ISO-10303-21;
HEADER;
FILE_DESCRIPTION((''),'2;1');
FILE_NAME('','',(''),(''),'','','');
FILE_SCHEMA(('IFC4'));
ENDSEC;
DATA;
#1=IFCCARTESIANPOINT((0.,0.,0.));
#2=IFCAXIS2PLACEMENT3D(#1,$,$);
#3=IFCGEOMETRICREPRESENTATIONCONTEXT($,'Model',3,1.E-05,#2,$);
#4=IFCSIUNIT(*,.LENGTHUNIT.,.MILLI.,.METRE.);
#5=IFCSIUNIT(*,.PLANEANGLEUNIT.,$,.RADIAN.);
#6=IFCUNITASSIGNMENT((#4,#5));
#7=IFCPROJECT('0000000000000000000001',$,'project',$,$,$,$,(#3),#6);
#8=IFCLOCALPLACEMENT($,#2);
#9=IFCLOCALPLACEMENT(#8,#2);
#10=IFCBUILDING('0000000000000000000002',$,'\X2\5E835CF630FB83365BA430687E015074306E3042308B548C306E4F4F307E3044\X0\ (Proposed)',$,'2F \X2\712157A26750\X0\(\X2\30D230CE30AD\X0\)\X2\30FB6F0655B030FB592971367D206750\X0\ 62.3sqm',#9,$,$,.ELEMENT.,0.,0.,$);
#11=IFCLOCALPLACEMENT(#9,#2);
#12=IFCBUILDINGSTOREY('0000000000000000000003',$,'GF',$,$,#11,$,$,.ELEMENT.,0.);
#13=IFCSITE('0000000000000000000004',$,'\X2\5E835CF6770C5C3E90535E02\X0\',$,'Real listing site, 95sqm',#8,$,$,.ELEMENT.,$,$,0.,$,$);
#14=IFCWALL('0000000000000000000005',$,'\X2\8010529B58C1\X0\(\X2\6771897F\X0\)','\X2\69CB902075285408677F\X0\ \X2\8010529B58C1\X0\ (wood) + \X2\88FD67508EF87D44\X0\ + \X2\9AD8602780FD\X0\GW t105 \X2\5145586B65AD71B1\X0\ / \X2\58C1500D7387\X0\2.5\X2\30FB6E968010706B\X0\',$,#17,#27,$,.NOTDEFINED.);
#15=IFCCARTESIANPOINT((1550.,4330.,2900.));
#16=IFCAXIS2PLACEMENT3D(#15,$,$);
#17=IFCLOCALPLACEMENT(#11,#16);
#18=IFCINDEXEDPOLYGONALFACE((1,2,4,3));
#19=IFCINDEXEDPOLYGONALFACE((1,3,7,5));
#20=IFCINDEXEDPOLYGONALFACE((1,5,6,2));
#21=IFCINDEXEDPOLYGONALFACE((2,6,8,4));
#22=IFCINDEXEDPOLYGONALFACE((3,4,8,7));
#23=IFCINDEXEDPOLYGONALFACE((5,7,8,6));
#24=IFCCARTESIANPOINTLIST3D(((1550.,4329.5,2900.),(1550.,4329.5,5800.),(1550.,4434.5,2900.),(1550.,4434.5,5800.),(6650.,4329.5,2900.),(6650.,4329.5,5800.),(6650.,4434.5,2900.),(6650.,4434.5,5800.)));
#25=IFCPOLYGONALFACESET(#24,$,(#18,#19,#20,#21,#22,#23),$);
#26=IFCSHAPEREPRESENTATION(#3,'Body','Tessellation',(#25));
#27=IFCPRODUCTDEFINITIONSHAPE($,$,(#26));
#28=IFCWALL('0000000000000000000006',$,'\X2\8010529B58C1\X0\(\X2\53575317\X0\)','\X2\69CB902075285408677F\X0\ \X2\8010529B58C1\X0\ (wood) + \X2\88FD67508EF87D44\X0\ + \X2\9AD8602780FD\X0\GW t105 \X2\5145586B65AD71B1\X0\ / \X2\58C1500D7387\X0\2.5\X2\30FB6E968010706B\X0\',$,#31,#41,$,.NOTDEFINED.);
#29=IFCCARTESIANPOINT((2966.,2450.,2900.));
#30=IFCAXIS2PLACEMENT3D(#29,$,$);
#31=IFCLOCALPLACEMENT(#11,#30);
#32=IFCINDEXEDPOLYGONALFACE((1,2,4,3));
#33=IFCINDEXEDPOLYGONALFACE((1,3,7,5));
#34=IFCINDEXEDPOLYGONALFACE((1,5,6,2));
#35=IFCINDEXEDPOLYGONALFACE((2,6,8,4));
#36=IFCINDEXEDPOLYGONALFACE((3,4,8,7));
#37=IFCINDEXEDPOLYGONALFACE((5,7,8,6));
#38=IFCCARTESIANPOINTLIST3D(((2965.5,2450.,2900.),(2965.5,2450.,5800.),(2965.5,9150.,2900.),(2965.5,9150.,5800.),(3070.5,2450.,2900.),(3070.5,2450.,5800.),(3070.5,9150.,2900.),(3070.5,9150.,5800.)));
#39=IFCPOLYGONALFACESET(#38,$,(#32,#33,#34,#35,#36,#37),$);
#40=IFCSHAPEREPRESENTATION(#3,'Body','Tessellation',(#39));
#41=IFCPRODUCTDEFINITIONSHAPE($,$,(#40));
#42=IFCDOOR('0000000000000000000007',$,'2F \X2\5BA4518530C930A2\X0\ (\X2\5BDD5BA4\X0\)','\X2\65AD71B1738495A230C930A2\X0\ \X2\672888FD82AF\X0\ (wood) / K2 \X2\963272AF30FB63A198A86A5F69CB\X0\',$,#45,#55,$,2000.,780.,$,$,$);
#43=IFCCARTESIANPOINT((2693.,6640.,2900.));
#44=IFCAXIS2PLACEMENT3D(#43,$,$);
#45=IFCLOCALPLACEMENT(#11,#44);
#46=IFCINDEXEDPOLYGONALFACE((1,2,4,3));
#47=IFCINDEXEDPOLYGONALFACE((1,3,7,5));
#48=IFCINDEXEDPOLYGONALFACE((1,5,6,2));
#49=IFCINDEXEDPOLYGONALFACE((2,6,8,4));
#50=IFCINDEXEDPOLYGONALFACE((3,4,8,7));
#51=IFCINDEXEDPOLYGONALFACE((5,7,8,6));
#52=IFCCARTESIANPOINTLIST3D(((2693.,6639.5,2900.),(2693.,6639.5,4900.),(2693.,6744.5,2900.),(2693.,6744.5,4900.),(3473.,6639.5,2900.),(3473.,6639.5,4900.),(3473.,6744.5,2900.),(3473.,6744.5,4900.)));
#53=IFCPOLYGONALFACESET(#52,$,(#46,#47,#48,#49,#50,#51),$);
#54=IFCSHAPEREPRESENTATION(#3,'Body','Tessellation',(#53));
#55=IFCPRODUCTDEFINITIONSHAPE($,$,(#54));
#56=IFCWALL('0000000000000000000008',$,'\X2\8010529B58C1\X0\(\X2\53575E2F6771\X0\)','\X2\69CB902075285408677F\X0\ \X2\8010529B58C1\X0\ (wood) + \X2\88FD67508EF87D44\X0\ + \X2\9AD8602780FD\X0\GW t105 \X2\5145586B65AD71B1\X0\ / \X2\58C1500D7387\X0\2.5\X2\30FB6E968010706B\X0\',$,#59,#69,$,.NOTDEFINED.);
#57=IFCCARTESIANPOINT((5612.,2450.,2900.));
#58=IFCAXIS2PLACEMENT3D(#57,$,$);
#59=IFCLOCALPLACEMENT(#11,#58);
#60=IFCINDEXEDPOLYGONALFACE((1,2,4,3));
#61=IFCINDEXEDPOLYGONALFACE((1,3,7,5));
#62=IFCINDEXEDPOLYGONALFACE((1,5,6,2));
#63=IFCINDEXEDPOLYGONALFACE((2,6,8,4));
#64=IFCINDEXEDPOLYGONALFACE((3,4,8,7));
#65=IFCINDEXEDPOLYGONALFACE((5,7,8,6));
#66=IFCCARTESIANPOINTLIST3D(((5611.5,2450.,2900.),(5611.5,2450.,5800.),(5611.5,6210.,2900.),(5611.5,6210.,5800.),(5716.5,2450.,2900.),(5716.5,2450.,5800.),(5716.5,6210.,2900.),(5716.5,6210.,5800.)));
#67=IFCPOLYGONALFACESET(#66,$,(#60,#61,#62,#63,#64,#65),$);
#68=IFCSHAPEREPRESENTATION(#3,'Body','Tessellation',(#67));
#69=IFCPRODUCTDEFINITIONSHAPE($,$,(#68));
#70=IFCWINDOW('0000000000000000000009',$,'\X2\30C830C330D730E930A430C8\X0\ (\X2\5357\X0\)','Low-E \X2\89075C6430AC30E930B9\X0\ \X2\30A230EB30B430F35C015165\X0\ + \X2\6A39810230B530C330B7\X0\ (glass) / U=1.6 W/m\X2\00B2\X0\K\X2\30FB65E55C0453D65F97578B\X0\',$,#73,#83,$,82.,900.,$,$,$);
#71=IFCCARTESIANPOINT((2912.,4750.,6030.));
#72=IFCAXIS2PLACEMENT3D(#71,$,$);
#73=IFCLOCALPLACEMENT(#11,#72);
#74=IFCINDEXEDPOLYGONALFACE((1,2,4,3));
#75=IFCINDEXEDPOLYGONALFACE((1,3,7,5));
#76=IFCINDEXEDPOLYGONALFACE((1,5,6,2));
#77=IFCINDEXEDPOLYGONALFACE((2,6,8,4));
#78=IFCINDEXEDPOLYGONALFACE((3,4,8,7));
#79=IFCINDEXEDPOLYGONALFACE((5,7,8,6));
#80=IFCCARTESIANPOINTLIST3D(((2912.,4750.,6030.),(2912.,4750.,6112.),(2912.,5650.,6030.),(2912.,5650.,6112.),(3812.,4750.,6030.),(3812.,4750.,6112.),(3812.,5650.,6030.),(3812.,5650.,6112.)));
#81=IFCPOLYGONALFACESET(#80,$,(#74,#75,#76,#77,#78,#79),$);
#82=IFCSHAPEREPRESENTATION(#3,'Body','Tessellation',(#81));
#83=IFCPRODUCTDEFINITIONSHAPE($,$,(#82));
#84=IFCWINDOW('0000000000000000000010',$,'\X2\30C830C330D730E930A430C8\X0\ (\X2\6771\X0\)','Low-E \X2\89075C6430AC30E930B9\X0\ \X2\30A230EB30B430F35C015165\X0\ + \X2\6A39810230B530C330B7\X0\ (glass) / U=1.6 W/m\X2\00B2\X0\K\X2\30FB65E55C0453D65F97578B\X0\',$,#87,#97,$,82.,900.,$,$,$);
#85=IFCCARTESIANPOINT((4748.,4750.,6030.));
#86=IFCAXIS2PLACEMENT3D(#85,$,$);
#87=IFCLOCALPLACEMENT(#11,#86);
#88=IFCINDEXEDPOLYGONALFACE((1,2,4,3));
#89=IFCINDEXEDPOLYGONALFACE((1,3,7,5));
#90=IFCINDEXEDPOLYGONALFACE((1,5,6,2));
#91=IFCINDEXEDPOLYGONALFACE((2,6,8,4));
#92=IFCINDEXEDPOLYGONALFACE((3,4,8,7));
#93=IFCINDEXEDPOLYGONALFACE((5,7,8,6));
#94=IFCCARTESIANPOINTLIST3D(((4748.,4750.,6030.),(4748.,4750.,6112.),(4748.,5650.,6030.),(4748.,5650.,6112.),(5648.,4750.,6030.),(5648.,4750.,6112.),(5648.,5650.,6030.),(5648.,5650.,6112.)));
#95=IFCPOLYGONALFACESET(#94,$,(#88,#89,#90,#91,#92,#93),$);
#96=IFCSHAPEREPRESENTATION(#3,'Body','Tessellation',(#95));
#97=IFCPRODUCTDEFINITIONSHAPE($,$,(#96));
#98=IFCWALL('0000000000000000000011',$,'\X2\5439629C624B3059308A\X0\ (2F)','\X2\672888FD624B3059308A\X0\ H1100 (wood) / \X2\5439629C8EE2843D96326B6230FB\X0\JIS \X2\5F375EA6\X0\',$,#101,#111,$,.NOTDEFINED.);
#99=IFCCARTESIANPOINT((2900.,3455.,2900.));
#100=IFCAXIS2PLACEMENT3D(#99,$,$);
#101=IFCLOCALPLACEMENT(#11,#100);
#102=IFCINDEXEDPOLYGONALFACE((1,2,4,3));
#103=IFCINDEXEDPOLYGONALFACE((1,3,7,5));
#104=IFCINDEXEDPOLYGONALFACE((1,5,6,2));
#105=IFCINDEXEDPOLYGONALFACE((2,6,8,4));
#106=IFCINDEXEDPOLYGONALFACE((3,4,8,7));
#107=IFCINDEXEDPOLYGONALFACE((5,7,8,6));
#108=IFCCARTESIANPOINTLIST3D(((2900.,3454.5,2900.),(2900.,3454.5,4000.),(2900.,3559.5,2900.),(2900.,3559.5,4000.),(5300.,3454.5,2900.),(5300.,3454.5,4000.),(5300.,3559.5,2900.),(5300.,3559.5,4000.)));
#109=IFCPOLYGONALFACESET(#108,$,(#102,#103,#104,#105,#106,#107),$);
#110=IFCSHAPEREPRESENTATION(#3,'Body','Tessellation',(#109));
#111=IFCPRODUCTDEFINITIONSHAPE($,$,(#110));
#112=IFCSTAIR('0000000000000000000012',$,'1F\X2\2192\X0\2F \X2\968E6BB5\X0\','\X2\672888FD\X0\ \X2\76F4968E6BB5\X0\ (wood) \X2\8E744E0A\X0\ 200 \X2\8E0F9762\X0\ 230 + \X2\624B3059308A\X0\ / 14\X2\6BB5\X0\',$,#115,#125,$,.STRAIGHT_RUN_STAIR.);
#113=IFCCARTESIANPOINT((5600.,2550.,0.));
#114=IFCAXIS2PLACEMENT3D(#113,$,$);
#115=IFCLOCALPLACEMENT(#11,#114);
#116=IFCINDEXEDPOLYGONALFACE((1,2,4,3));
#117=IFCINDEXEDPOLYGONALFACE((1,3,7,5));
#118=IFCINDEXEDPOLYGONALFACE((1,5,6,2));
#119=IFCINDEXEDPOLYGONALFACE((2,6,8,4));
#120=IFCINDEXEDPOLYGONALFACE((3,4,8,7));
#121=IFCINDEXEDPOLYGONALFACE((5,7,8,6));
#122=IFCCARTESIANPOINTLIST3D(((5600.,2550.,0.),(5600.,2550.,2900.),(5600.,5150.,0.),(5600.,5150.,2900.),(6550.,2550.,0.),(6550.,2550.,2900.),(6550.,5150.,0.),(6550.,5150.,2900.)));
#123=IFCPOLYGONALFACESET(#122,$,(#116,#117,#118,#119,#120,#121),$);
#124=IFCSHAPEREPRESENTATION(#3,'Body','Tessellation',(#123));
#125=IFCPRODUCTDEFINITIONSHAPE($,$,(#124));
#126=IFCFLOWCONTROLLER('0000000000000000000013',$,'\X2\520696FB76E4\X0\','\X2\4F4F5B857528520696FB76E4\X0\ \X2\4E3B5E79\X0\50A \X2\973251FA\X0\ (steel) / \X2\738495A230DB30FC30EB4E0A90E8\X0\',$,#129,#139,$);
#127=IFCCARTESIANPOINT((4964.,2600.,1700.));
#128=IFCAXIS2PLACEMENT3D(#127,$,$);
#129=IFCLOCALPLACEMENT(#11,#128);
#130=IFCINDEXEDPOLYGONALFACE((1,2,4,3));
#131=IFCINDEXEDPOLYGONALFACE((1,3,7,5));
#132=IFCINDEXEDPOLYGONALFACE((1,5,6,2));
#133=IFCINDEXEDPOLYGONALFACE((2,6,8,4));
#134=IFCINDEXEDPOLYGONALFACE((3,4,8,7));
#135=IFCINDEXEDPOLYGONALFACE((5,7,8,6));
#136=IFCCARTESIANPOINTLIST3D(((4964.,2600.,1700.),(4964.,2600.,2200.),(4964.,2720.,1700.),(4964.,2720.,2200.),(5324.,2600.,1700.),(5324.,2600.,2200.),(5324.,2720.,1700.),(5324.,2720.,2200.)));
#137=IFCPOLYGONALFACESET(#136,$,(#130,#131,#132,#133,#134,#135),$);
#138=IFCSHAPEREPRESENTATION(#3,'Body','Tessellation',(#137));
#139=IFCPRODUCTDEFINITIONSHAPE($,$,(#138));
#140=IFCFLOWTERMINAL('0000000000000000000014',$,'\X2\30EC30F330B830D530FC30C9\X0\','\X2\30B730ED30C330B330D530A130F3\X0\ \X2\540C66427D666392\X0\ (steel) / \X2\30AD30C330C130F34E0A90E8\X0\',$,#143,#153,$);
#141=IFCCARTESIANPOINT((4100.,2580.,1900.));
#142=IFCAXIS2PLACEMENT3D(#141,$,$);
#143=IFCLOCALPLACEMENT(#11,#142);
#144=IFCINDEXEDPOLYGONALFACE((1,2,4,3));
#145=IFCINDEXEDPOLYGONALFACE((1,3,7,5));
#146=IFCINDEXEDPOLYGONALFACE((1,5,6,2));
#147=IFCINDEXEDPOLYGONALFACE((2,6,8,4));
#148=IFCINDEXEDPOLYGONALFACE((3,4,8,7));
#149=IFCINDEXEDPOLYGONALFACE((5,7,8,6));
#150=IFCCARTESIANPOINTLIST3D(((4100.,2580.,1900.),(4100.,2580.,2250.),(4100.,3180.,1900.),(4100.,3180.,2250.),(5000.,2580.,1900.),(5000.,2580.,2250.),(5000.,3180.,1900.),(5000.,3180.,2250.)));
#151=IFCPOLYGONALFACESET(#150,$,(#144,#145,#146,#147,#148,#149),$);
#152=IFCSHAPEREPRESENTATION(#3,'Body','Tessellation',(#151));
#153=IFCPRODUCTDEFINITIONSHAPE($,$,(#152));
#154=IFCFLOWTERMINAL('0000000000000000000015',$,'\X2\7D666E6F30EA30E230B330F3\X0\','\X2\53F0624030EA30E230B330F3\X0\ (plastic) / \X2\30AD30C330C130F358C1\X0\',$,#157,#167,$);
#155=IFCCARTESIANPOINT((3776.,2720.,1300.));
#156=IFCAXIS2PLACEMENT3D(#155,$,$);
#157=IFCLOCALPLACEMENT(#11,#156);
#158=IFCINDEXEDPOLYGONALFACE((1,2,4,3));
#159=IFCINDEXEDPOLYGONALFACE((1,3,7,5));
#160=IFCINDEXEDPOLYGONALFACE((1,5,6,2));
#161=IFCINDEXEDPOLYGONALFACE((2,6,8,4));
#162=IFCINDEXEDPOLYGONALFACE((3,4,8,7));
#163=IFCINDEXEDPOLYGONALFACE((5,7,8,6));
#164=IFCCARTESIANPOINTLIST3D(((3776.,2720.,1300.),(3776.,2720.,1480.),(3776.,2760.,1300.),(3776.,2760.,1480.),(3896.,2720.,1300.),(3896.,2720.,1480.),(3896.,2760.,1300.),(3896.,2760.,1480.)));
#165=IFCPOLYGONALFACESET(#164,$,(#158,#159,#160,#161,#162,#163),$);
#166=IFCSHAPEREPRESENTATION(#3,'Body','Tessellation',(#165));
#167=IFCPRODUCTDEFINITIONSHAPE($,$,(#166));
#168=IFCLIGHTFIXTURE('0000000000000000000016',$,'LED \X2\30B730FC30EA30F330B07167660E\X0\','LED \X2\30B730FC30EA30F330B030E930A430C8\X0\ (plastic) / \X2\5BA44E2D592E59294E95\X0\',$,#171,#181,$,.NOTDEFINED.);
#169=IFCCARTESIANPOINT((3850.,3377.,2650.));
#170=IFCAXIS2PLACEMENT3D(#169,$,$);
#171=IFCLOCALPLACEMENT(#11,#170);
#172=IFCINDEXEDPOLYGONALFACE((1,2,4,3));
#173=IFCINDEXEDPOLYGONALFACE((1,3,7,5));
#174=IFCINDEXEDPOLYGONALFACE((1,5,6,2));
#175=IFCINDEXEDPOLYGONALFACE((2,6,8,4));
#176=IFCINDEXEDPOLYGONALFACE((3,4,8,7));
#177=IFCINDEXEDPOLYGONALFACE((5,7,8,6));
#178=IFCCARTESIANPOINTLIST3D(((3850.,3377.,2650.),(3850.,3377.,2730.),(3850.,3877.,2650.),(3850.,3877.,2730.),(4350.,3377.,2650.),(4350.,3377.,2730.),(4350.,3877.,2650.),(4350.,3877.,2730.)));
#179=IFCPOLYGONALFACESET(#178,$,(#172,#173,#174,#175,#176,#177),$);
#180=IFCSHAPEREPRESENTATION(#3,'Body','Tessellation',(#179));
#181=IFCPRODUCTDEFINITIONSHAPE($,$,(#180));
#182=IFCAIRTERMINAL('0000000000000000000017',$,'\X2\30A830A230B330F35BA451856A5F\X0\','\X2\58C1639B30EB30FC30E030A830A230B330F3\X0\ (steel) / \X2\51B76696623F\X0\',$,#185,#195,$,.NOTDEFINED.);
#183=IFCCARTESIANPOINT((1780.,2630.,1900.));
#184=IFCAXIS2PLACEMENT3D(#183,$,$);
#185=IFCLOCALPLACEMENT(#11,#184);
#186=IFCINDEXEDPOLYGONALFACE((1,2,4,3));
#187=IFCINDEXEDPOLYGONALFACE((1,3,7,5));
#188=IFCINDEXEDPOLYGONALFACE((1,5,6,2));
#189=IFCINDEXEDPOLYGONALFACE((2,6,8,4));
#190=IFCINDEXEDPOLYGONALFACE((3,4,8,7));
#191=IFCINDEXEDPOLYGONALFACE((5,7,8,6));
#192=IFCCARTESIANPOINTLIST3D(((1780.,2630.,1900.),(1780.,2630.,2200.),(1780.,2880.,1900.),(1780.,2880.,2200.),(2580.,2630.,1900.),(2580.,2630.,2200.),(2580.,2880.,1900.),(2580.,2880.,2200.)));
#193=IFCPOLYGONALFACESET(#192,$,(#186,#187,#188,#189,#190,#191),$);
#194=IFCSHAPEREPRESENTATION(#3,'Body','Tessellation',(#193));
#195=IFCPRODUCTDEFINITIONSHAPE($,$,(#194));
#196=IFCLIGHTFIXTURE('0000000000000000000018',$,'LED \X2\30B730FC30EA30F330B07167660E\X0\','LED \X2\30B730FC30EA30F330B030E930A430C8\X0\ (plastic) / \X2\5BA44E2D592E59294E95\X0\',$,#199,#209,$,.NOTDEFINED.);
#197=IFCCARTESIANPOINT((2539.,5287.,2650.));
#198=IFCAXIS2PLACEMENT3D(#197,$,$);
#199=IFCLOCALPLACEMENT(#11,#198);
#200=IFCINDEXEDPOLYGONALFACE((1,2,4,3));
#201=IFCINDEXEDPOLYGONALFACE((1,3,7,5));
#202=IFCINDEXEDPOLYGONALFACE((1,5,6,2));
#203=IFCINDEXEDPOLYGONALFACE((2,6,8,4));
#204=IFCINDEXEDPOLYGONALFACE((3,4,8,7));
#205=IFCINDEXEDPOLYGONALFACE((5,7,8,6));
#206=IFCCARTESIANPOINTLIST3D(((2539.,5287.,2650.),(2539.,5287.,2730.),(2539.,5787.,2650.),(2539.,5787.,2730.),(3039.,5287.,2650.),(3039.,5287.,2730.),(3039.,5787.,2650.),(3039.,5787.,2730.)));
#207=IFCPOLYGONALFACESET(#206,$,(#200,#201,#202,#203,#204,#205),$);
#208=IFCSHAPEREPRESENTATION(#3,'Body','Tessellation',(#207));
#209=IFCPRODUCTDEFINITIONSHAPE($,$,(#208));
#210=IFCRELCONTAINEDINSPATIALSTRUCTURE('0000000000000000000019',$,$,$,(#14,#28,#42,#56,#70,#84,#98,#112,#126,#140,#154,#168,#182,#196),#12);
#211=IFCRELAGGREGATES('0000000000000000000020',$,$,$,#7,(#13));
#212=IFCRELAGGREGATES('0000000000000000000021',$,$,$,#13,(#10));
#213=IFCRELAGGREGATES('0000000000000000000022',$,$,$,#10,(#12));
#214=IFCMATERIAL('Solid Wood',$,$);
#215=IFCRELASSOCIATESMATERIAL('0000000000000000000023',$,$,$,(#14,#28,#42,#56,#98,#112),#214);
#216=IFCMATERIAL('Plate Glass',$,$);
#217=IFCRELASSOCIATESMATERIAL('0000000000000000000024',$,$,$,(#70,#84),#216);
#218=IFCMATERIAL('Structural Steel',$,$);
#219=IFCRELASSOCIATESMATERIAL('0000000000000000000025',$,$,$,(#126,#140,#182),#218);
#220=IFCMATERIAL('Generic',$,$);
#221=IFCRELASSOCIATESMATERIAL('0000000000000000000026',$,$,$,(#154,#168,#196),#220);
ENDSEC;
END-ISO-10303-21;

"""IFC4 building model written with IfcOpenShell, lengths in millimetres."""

from ifc_helpers import new_model, si_unit, frame, frame_2d, origin, place, context, project, spatial, rectangle, extrude, material, element, fill, save


model = new_model("IFC4")

# Units and contexts
model_context = context("Model", 3, precision=1e-05, world=origin())
ifc_project = project(units=[si_unit("LENGTHUNIT", "METRE", prefix="MILLI"), si_unit("PLANEANGLEUNIT", "RADIAN")], contexts=[model_context])

# Site, building, storey
site_placement = place(None, origin())
site = spatial("IfcSite", under=ifc_project, at=site_placement, Name="広島県尾道市", ObjectType="Real listing site, 95sqm", CompositionType="ELEMENT", RefElevation=0.0)
building_placement = place(site_placement, origin())
building = spatial("IfcBuilding", under=site, at=building_placement, Name="広島・茶室と縁側のある和の住まい (Proposed)", ObjectType="2F 無垢材(ヒノキ)・漆喰・天然素材 62.3sqm", CompositionType="ELEMENT", ElevationOfRefHeight=0.0, ElevationOfTerrain=0.0)
storey_placement = place(building_placement, origin())
storey = spatial("IfcBuildingStorey", under=building, at=storey_placement, Name="GF", CompositionType="ELEMENT", Elevation=0.0)

# Shared definitions
ifc_material_1 = material(Name="Solid Wood")

# Wall
wall_1_placement = place(storey_placement, frame((1550.0, 4330.0, 2900.0)))
element("IfcWall", 1, at=wall_1_placement, inside=storey, material=ifc_material_1, Name="耐力壁(東西)", Description="構造用合板 耐力壁 (wood) + 製材軸組 + 高性能GW t105 充填断熱 / 壁倍率2.5・準耐火", PredefinedType="NOTDEFINED", context=model_context, shape_type="SweptSolid", body=[
    extrude(rectangle(XDim=5100.0, YDim=105.0, at=frame_2d((2550.0, 52.0))), frame((1550.0, 4330.0, 2900.0)), (0.0, 0.0, 1.0), 2900.0),
])

# Wall, opening, door
wall_2_placement = place(storey_placement, frame((2966.0, 2450.0, 2900.0)))
wall_2 = element("IfcWall", 2, at=wall_2_placement, inside=storey, material=ifc_material_1, Name="耐力壁(南北)", Description="構造用合板 耐力壁 (wood) + 製材軸組 + 高性能GW t105 充填断熱 / 壁倍率2.5・準耐火", PredefinedType="NOTDEFINED", context=model_context, shape_type="SweptSolid", body=[
    extrude(rectangle(XDim=105.0, YDim=6700.0, at=frame_2d((52.0, 3350.0))), frame((2966.0, 2450.0, 2900.0)), (0.0, 0.0, 1.0), 2900.0),
])
opening_placement = place(storey_placement, frame((2693.0, 6640.0, 2900.0)))
opening = element("IfcOpeningElement", 3, at=opening_placement, cuts=wall_2, PredefinedType="NOTDEFINED", context=model_context, shape_type="SweptSolid", body=[
    extrude(rectangle(XDim=780.0, YDim=105.0, at=frame_2d((390.0, 52.0))), frame((2693.0, 6640.0, 2900.0)), (0.0, 0.0, 1.0), 2000.0),
])
door_placement = place(storey_placement, frame((2693.0, 6640.0, 2900.0)))
door = element("IfcDoor", 4, at=door_placement, inside=storey, material=ifc_material_1, Name="2F 室内ドア (寝室)", Description="断熱玄関ドア 木製芯 (wood) / K2 防犯・採風機構", OverallHeight=2000.0, OverallWidth=780.0, context=model_context, shape_type="SweptSolid", body=[
    extrude(rectangle(XDim=780.0, YDim=105.0, at=frame_2d((390.0, 52.0))), frame((2693.0, 6640.0, 2900.0)), (0.0, 0.0, 1.0), 2000.0),
])
fill(opening, door)

# Wall
wall_3_placement = place(storey_placement, frame((5612.0, 2450.0, 2900.0)))
element("IfcWall", 5, at=wall_3_placement, inside=storey, material=ifc_material_1, Name="耐力壁(南帯東)", Description="構造用合板 耐力壁 (wood) + 製材軸組 + 高性能GW t105 充填断熱 / 壁倍率2.5・準耐火", PredefinedType="NOTDEFINED", context=model_context, shape_type="SweptSolid", body=[
    extrude(rectangle(XDim=105.0, YDim=3760.0, at=frame_2d((52.0, 1880.0))), frame((5612.0, 2450.0, 2900.0)), (0.0, 0.0, 1.0), 2900.0),
])

# Windows
ifc_material_2 = material(Name="Plate Glass")
window_1_placement = place(storey_placement, frame((2912.0, 4750.0, 6030.0)))
element("IfcWindow", 6, at=window_1_placement, inside=storey, material=ifc_material_2, Name="トップライト (南)", Description="Low-E 複層ガラス アルゴン封入 + 樹脂サッシ (glass) / U=1.6 W/m²K・日射取得型", OverallHeight=82.0, OverallWidth=900.0, context=model_context, shape_type="SweptSolid", body=[
    extrude(rectangle(XDim=900.0, YDim=900.0, at=frame_2d((450.0, 450.0))), frame((2912.0, 4750.0, 6030.0)), (0.0, 0.0, 1.0), 82.0),
])
window_2_placement = place(storey_placement, frame((4748.0, 4750.0, 6030.0)))
element("IfcWindow", 7, at=window_2_placement, inside=storey, material=ifc_material_2, Name="トップライト (東)", Description="Low-E 複層ガラス アルゴン封入 + 樹脂サッシ (glass) / U=1.6 W/m²K・日射取得型", OverallHeight=82.0, OverallWidth=900.0, context=model_context, shape_type="SweptSolid", body=[
    extrude(rectangle(XDim=900.0, YDim=900.0, at=frame_2d((450.0, 450.0))), frame((4748.0, 4750.0, 6030.0)), (0.0, 0.0, 1.0), 82.0),
])

# Wall
wall_4_placement = place(storey_placement, frame((2900.0, 3455.0, 2900.0)))
element("IfcWall", 8, at=wall_4_placement, inside=storey, material=ifc_material_1, Name="吹抜手すり (2F)", Description="木製手すり H1100 (wood) / 吹抜転落防止・JIS 強度", PredefinedType="NOTDEFINED", context=model_context, shape_type="SweptSolid", body=[
    extrude(rectangle(XDim=2400.0, YDim=105.0, at=frame_2d((1200.0, 52.0))), frame((2900.0, 3455.0, 2900.0)), (0.0, 0.0, 1.0), 1100.0),
])

# Stair
stair_placement = place(storey_placement, frame((5600.0, 2550.0, 0.0)))
element("IfcStair", 9, at=stair_placement, inside=storey, material=ifc_material_1, Name="1F→2F 階段", Description="木製 直階段 (wood) 蹴上 200 踏面 230 + 手すり / 14段", PredefinedType="STRAIGHT_RUN_STAIR", context=model_context, shape_type="SweptSolid", body=[
    extrude(rectangle(XDim=950.0, YDim=2600.0, at=frame_2d((475.0, 1300.0))), frame((5600.0, 2550.0, 0.0)), (0.0, 0.0, 1.0), 2900.0),
])

# Shared definitions
ifc_material_3 = material(Name="Structural Steel")

# Flow controller
flow_controller_placement = place(storey_placement, frame((4964.0, 2600.0, 1700.0)))
element("IfcFlowController", 10, at=flow_controller_placement, inside=storey, material=ifc_material_3, Name="分電盤", Description="住宅用分電盤 主幹50A 露出 (steel) / 玄関ホール上部", context=model_context, shape_type="SweptSolid", body=[
    extrude(rectangle(XDim=360.0, YDim=120.0, at=frame_2d((180.0, 60.0))), frame((4964.0, 2600.0, 1700.0)), (0.0, 0.0, 1.0), 500.0),
])

# Flow terminals
flow_terminal_1_placement = place(storey_placement, frame((4100.0, 2580.0, 1900.0)))
element("IfcFlowTerminal", 11, at=flow_terminal_1_placement, inside=storey, material=ifc_material_3, Name="レンジフード", Description="シロッコファン 同時給排 (steel) / キッチン上部", context=model_context, shape_type="SweptSolid", body=[
    extrude(rectangle(XDim=900.0, YDim=600.0, at=frame_2d((450.0, 300.0))), frame((4100.0, 2580.0, 1900.0)), (0.0, 0.0, 1.0), 350.0),
])
ifc_material_4 = material(Name="Generic")
flow_terminal_2_placement = place(storey_placement, frame((3776.0, 2720.0, 1300.0)))
element("IfcFlowTerminal", 12, at=flow_terminal_2_placement, inside=storey, material=ifc_material_4, Name="給湯リモコン", Description="台所リモコン (plastic) / キッチン壁", context=model_context, shape_type="SweptSolid", body=[
    extrude(rectangle(XDim=120.0, YDim=40.0, at=frame_2d((60.0, 20.0))), frame((3776.0, 2720.0, 1300.0)), (0.0, 0.0, 1.0), 180.0),
])

# Light fixture
light_fixture_1_placement = place(storey_placement, frame((3850.0, 3377.0, 2650.0)))
element("IfcLightFixture", 13, at=light_fixture_1_placement, inside=storey, material=ifc_material_4, Name="LED シーリング照明", Description="LED シーリングライト (plastic) / 室中央天井", PredefinedType="NOTDEFINED", context=model_context, shape_type="SweptSolid", body=[
    extrude(rectangle(XDim=500.0, YDim=500.0, at=frame_2d((250.0, 250.0))), frame((3850.0, 3377.0, 2650.0)), (0.0, 0.0, 1.0), 80.0),
])

# Air terminal
air_terminal_1_placement = place(storey_placement, frame((1780.0, 2630.0, 1900.0)))
element("IfcAirTerminal", 14, at=air_terminal_1_placement, inside=storey, material=ifc_material_3, Name="エアコン室内機", Description="壁掛ルームエアコン (steel) / 冷暖房", PredefinedType="NOTDEFINED", context=model_context, shape_type="SweptSolid", body=[
    extrude(rectangle(XDim=800.0, YDim=250.0, at=frame_2d((400.0, 125.0))), frame((1780.0, 2630.0, 1900.0)), (0.0, 0.0, 1.0), 300.0),
])

# Light fixture
light_fixture_2_placement = place(storey_placement, frame((2539.0, 5287.0, 2650.0)))
element("IfcLightFixture", 15, at=light_fixture_2_placement, inside=storey, material=ifc_material_4, Name="LED シーリング照明", Description="LED シーリングライト (plastic) / 室中央天井", PredefinedType="NOTDEFINED", context=model_context, shape_type="SweptSolid", body=[
    extrude(rectangle(XDim=500.0, YDim=500.0, at=frame_2d((250.0, 250.0))), frame((2539.0, 5287.0, 2650.0)), (0.0, 0.0, 1.0), 80.0),
])

save(model, "model.ifc")
